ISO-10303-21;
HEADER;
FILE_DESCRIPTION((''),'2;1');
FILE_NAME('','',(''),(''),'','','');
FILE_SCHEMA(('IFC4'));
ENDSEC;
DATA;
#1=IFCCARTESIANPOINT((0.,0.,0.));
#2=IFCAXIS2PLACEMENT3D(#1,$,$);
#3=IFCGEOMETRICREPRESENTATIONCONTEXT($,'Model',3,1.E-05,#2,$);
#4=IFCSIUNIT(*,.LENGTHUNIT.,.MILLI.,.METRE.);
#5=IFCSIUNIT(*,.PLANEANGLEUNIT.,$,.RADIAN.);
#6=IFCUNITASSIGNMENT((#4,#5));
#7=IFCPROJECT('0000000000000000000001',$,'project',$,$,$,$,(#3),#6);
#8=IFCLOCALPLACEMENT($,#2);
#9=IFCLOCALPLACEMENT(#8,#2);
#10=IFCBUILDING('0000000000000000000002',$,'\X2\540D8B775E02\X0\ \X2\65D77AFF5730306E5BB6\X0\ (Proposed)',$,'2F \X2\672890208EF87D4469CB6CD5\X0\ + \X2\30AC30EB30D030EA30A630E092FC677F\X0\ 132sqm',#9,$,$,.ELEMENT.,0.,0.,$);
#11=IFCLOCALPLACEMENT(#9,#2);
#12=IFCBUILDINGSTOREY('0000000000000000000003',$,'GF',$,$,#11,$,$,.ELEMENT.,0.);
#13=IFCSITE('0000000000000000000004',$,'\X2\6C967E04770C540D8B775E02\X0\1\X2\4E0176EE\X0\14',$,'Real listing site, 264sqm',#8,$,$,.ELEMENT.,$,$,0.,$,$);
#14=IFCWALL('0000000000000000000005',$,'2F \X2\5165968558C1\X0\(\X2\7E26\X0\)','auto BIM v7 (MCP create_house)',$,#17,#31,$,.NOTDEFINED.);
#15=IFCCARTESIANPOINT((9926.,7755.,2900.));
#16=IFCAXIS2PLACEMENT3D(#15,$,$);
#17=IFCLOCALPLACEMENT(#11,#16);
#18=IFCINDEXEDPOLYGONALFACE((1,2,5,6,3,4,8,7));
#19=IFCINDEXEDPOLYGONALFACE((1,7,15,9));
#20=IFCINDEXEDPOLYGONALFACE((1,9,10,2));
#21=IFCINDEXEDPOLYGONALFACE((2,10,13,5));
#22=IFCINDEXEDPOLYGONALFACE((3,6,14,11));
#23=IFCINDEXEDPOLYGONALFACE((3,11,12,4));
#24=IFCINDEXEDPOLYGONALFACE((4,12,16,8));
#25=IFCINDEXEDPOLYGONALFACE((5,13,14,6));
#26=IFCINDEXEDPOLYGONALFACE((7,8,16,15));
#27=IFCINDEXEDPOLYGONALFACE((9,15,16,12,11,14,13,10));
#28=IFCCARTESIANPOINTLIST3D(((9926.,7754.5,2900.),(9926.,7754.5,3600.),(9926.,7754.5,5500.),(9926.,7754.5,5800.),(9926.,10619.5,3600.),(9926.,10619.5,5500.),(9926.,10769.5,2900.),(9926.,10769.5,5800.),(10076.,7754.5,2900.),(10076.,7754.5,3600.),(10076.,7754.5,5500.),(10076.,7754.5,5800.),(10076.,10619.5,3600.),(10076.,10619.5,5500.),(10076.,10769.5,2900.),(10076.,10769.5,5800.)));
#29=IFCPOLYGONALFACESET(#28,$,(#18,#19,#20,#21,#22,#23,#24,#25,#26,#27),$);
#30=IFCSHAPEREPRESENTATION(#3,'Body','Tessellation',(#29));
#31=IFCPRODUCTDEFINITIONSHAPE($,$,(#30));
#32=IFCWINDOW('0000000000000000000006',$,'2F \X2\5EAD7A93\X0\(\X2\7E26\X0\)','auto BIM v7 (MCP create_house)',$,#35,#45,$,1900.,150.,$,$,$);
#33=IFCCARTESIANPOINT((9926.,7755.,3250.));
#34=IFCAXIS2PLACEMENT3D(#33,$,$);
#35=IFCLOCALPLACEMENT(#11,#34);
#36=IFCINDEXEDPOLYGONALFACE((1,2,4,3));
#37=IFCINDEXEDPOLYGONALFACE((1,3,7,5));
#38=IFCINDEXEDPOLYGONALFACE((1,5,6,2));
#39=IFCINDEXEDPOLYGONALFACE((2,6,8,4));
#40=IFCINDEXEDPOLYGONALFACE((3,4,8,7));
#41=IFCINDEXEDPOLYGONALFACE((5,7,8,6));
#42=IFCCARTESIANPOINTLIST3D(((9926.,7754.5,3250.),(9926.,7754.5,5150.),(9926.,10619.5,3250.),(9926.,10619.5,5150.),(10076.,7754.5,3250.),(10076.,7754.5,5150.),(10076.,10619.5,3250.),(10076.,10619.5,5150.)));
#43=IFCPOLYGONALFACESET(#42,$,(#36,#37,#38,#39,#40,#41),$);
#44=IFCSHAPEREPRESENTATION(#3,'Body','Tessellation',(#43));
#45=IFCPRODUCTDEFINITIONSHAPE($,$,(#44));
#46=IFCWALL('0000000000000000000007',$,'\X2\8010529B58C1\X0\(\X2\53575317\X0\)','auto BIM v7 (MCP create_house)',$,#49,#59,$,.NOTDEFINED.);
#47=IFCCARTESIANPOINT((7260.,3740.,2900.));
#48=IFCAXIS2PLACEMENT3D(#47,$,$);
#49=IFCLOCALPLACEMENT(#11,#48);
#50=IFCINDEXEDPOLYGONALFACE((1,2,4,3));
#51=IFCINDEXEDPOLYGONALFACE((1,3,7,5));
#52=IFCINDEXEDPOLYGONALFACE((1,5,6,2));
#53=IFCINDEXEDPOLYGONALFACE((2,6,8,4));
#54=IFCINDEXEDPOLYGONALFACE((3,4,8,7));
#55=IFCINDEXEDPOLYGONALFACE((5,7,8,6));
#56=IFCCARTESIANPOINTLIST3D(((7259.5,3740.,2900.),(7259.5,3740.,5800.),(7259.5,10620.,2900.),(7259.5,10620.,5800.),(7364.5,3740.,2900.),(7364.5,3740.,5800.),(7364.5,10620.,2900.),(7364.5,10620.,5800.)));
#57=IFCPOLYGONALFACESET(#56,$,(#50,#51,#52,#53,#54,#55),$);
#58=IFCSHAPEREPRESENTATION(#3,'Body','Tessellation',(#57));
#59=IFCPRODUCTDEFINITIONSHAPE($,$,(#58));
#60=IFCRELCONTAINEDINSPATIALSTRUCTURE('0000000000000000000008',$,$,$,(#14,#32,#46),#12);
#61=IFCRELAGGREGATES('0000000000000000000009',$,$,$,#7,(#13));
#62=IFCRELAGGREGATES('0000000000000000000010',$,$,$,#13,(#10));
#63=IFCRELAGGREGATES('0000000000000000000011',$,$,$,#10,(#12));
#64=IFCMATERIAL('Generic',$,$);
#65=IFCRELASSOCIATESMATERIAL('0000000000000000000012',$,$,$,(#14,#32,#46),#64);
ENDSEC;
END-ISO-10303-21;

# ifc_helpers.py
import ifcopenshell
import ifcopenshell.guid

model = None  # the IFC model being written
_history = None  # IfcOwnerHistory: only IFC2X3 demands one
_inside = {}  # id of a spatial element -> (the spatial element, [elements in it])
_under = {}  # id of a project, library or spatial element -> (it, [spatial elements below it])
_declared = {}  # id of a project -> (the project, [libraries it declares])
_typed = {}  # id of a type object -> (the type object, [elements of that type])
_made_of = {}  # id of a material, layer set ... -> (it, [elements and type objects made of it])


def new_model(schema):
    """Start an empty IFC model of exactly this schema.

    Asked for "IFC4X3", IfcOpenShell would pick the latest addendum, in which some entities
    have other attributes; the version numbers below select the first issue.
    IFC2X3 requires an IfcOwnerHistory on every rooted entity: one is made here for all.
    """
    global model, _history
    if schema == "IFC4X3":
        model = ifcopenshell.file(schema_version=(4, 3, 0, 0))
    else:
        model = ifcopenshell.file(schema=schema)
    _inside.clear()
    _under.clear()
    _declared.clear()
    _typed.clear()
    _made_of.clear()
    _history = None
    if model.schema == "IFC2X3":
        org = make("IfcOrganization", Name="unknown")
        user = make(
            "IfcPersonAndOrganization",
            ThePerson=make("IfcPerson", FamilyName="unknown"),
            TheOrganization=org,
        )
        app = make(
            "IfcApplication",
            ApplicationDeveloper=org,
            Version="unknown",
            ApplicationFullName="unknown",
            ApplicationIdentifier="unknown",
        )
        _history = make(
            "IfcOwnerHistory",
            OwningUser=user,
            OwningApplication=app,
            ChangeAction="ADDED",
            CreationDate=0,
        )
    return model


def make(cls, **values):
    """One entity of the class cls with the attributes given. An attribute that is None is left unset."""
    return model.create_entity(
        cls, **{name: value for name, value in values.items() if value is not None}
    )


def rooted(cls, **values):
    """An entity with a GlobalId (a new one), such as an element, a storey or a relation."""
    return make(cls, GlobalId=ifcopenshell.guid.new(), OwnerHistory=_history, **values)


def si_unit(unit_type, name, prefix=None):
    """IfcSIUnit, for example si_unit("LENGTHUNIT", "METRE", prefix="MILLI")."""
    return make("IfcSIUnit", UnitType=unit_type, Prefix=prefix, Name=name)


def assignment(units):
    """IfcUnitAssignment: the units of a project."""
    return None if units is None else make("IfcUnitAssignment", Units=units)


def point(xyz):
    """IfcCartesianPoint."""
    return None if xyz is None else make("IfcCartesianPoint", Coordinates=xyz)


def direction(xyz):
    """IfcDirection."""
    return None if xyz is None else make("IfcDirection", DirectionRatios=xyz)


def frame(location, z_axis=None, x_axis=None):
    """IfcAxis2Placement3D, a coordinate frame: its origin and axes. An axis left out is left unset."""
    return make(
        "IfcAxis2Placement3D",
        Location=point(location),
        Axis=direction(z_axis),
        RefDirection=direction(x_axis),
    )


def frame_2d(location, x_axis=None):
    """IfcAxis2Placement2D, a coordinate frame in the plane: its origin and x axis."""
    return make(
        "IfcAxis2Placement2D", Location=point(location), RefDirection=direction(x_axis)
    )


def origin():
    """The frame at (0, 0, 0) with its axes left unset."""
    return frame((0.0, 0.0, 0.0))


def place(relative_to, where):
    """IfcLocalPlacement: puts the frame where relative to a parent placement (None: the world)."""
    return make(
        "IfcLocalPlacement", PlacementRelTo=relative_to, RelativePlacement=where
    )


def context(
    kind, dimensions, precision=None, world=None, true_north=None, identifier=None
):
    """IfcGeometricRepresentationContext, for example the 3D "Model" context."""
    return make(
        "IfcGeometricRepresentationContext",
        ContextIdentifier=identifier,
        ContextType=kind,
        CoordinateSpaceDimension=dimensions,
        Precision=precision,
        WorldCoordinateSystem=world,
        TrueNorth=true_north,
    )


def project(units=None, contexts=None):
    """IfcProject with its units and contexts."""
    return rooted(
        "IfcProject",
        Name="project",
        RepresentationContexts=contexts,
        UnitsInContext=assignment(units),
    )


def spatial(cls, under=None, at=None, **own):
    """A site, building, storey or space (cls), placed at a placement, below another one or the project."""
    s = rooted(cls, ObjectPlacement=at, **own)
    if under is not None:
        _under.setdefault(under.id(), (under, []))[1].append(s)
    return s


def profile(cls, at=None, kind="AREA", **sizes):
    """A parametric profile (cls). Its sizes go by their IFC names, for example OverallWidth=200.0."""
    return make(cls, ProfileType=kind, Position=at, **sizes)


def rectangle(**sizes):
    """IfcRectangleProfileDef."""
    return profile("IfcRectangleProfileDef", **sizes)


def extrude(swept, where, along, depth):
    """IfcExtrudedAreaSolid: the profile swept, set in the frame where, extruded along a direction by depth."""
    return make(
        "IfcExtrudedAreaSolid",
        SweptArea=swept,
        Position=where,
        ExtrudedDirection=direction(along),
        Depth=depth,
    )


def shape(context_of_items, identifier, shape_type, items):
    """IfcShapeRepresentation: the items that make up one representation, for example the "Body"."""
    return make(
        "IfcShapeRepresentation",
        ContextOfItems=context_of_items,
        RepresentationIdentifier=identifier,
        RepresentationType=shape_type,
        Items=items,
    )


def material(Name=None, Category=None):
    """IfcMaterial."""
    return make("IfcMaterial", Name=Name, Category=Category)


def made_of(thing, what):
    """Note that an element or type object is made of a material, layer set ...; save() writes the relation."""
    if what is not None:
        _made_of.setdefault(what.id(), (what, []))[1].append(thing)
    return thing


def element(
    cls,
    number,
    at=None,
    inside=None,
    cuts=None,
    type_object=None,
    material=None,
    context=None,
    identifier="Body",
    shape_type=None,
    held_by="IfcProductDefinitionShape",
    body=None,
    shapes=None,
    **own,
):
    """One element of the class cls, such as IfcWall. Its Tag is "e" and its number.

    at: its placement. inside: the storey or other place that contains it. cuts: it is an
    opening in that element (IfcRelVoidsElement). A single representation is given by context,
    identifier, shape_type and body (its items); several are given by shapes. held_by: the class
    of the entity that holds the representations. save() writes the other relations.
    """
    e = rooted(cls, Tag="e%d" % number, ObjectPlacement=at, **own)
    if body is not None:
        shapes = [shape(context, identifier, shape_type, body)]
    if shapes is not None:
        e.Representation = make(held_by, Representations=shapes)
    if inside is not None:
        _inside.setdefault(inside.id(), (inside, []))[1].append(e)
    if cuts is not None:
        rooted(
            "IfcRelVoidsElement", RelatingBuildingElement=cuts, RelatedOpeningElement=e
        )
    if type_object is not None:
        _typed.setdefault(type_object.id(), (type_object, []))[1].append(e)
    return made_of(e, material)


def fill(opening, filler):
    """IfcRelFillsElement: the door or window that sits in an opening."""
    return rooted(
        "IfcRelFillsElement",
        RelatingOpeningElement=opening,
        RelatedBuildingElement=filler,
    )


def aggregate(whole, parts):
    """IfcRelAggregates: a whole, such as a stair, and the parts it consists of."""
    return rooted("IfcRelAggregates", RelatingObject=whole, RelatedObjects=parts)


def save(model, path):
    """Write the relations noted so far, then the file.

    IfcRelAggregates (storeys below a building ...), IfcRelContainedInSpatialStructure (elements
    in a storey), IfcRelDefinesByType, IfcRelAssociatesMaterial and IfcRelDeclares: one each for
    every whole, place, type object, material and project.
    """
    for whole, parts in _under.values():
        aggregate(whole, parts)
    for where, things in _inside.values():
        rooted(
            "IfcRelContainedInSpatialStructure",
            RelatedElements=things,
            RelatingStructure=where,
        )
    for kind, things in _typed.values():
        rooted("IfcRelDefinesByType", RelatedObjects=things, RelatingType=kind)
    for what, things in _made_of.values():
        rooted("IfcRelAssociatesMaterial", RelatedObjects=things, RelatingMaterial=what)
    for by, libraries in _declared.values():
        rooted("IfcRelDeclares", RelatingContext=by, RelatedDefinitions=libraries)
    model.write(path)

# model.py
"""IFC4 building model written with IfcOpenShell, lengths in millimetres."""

from ifc_helpers import new_model, si_unit, frame, frame_2d, origin, place, context, project, spatial, rectangle, extrude, material, element, fill, save


model = new_model("IFC4")

# Units and contexts
model_context = context("Model", 3, precision=1e-05, world=origin())
ifc_project = project(units=[si_unit("LENGTHUNIT", "METRE", prefix="MILLI"), si_unit("PLANEANGLEUNIT", "RADIAN")], contexts=[model_context])

# Site, building, storey
site_placement = place(None, origin())
site = spatial("IfcSite", under=ifc_project, at=site_placement, Name="沖縄県名護市1丁目14", ObjectType="Real listing site, 264sqm", CompositionType="ELEMENT", RefElevation=0.0)
building_placement = place(site_placement, origin())
building = spatial("IfcBuilding", under=site, at=building_placement, Name="名護市 旗竿地の家 (Proposed)", ObjectType="2F 木造軸組構法 + ガルバリウム鋼板 132sqm", CompositionType="ELEMENT", ElevationOfRefHeight=0.0, ElevationOfTerrain=0.0)
storey_placement = place(building_placement, origin())
storey = spatial("IfcBuildingStorey", under=building, at=storey_placement, Name="GF", CompositionType="ELEMENT", Elevation=0.0)

# Shared definitions
ifc_material = material(Name="Generic")

# Wall, opening, window
wall_1_placement = place(storey_placement, frame((9926.0, 7755.0, 2900.0)))
wall_1 = element("IfcWall", 1, at=wall_1_placement, inside=storey, material=ifc_material, Name="2F 入隅壁(縦)", Description="auto BIM v7 (MCP create_house)", PredefinedType="NOTDEFINED", context=model_context, shape_type="SweptSolid", body=[
    extrude(rectangle(XDim=150.0, YDim=3015.0, at=frame_2d((75.0, 1507.0))), frame((9926.0, 7755.0, 2900.0)), (0.0, 0.0, 1.0), 2900.0),
])
opening_1_placement = place(storey_placement, frame((9926.0, 7755.0, 3250.0)))
opening_1 = element("IfcOpeningElement", 2, at=opening_1_placement, cuts=wall_1, PredefinedType="NOTDEFINED", context=model_context, shape_type="SweptSolid", body=[
    extrude(rectangle(XDim=150.0, YDim=2865.0, at=frame_2d((75.0, 1432.0))), frame((9926.0, 7755.0, 3250.0)), (0.0, 0.0, 1.0), 1900.0),
])
window_1_placement = place(storey_placement, frame((9926.0, 7755.0, 3250.0)))
window_1 = element("IfcWindow", 3, at=window_1_placement, inside=storey, material=ifc_material, Name="2F 庭窓(縦)", Description="auto BIM v7 (MCP create_house)", OverallHeight=1900.0, OverallWidth=150.0, context=model_context, shape_type="SweptSolid", body=[
    extrude(rectangle(XDim=150.0, YDim=2865.0, at=frame_2d((75.0, 1432.0))), frame((9926.0, 7755.0, 3250.0)), (0.0, 0.0, 1.0), 1900.0),
])
fill(opening_1, window_1)

# Wall
wall_2_placement = place(storey_placement, frame((7260.0, 3740.0, 2900.0)))
element("IfcWall", 4, at=wall_2_placement, inside=storey, material=ifc_material, Name="耐力壁(南北)", Description="auto BIM v7 (MCP create_house)", PredefinedType="NOTDEFINED", context=model_context, shape_type="SweptSolid", body=[
    extrude(rectangle(XDim=105.0, YDim=6880.0, at=frame_2d((52.0, 3440.0))), frame((7260.0, 3740.0, 2900.0)), (0.0, 0.0, 1.0), 2900.0),
])

save(model, "model.ifc")
